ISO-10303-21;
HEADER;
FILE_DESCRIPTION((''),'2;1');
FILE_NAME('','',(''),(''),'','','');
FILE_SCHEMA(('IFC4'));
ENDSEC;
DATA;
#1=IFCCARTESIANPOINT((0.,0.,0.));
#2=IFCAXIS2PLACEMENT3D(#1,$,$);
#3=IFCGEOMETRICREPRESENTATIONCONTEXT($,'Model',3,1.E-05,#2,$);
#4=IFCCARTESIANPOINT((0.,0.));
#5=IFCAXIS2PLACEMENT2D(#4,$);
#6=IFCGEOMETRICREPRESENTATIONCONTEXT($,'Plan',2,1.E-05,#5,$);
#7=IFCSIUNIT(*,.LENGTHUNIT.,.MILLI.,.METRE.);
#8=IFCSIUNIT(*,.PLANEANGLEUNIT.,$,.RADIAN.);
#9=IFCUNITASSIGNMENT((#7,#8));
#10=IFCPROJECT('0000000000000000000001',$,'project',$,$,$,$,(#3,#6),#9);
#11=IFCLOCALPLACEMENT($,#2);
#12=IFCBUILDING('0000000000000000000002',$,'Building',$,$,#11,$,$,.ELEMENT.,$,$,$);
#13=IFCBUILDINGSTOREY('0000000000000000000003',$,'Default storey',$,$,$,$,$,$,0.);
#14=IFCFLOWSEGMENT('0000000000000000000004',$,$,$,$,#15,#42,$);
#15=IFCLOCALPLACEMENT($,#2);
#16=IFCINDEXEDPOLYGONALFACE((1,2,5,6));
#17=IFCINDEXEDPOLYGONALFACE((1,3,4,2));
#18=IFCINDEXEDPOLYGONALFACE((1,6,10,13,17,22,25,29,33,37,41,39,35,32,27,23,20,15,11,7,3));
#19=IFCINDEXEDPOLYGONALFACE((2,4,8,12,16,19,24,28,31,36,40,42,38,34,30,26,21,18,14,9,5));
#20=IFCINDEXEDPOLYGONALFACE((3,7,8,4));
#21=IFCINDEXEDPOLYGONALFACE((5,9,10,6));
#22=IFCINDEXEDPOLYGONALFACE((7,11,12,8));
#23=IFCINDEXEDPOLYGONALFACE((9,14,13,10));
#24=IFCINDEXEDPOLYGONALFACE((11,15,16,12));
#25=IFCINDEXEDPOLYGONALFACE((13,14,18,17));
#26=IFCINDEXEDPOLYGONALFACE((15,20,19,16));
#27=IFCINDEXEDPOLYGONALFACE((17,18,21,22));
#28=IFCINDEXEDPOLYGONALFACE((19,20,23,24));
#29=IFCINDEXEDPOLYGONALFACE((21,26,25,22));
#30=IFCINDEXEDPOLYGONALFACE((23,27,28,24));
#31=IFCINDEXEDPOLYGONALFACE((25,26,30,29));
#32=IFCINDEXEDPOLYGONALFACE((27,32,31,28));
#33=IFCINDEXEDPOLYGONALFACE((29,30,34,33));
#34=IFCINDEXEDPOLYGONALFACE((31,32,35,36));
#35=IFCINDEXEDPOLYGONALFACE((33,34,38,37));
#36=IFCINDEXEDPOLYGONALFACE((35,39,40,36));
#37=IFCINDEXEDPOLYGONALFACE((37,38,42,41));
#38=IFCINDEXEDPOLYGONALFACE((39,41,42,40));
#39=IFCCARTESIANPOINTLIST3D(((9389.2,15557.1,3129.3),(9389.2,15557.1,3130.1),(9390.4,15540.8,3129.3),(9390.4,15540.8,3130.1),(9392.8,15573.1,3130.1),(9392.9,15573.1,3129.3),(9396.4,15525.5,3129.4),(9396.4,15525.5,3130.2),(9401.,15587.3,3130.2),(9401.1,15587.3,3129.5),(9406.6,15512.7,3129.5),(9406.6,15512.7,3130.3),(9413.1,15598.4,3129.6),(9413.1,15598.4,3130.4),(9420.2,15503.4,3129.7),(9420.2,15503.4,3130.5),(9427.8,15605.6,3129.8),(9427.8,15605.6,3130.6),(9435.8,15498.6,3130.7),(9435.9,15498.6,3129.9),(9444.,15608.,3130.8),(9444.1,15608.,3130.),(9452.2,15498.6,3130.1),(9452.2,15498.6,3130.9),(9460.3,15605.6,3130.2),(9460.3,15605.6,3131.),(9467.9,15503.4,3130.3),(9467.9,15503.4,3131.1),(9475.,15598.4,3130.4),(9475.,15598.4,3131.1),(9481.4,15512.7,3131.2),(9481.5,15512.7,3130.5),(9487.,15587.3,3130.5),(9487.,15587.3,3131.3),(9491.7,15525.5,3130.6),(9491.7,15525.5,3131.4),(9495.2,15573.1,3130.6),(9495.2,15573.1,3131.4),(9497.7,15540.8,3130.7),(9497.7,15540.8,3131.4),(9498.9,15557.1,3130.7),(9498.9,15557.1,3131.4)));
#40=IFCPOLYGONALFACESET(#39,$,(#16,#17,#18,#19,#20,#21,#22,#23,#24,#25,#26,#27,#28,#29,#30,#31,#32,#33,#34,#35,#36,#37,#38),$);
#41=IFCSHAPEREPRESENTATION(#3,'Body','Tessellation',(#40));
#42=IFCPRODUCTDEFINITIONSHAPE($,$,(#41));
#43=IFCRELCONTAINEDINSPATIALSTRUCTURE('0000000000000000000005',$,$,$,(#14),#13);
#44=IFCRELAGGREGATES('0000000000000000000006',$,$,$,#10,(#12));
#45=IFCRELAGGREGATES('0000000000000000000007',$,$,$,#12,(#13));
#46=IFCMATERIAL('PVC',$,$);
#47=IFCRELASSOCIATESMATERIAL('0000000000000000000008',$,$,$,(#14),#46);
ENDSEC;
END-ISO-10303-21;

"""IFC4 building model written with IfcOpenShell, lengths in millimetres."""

from ifc_helpers import new_model, si_unit, frame, origin, origin_2d, place, context, project, spatial, circle, extrude, material, element, save


model = new_model("IFC4")

# Units and contexts
model_context = context("Model", 3, precision=1e-05, world=origin())
plan_context = context("Plan", 2, precision=1e-05, world=origin_2d())
ifc_project = project(units=[si_unit("LENGTHUNIT", "METRE", prefix="MILLI"), si_unit("PLANEANGLEUNIT", "RADIAN")], contexts=[model_context, plan_context])

# Building, storey
placement = place(None, origin())
building = spatial("IfcBuilding", under=ifc_project, at=placement, Name="Building", CompositionType="ELEMENT")
storey = spatial("IfcBuildingStorey", under=building, Name="Default storey", Elevation=0.0)

# Flow segment
ifc_material_1 = material(Name="PVC")
element("IfcFlowSegment", 1, at=placement, inside=storey, material=ifc_material_1, context=model_context, shape_type="SweptSolid", body=[
    extrude(circle(Radius=55.0, at=origin_2d()), frame((9444.1, 15553.0, 3130.0), z_axis=(-0.009595, 0.0, 0.767565), x_axis=(0.0, 9.594563, 0.0)), (0.0, 0.0, 1.0), 0.8),
])

save(model, "model.ifc")
